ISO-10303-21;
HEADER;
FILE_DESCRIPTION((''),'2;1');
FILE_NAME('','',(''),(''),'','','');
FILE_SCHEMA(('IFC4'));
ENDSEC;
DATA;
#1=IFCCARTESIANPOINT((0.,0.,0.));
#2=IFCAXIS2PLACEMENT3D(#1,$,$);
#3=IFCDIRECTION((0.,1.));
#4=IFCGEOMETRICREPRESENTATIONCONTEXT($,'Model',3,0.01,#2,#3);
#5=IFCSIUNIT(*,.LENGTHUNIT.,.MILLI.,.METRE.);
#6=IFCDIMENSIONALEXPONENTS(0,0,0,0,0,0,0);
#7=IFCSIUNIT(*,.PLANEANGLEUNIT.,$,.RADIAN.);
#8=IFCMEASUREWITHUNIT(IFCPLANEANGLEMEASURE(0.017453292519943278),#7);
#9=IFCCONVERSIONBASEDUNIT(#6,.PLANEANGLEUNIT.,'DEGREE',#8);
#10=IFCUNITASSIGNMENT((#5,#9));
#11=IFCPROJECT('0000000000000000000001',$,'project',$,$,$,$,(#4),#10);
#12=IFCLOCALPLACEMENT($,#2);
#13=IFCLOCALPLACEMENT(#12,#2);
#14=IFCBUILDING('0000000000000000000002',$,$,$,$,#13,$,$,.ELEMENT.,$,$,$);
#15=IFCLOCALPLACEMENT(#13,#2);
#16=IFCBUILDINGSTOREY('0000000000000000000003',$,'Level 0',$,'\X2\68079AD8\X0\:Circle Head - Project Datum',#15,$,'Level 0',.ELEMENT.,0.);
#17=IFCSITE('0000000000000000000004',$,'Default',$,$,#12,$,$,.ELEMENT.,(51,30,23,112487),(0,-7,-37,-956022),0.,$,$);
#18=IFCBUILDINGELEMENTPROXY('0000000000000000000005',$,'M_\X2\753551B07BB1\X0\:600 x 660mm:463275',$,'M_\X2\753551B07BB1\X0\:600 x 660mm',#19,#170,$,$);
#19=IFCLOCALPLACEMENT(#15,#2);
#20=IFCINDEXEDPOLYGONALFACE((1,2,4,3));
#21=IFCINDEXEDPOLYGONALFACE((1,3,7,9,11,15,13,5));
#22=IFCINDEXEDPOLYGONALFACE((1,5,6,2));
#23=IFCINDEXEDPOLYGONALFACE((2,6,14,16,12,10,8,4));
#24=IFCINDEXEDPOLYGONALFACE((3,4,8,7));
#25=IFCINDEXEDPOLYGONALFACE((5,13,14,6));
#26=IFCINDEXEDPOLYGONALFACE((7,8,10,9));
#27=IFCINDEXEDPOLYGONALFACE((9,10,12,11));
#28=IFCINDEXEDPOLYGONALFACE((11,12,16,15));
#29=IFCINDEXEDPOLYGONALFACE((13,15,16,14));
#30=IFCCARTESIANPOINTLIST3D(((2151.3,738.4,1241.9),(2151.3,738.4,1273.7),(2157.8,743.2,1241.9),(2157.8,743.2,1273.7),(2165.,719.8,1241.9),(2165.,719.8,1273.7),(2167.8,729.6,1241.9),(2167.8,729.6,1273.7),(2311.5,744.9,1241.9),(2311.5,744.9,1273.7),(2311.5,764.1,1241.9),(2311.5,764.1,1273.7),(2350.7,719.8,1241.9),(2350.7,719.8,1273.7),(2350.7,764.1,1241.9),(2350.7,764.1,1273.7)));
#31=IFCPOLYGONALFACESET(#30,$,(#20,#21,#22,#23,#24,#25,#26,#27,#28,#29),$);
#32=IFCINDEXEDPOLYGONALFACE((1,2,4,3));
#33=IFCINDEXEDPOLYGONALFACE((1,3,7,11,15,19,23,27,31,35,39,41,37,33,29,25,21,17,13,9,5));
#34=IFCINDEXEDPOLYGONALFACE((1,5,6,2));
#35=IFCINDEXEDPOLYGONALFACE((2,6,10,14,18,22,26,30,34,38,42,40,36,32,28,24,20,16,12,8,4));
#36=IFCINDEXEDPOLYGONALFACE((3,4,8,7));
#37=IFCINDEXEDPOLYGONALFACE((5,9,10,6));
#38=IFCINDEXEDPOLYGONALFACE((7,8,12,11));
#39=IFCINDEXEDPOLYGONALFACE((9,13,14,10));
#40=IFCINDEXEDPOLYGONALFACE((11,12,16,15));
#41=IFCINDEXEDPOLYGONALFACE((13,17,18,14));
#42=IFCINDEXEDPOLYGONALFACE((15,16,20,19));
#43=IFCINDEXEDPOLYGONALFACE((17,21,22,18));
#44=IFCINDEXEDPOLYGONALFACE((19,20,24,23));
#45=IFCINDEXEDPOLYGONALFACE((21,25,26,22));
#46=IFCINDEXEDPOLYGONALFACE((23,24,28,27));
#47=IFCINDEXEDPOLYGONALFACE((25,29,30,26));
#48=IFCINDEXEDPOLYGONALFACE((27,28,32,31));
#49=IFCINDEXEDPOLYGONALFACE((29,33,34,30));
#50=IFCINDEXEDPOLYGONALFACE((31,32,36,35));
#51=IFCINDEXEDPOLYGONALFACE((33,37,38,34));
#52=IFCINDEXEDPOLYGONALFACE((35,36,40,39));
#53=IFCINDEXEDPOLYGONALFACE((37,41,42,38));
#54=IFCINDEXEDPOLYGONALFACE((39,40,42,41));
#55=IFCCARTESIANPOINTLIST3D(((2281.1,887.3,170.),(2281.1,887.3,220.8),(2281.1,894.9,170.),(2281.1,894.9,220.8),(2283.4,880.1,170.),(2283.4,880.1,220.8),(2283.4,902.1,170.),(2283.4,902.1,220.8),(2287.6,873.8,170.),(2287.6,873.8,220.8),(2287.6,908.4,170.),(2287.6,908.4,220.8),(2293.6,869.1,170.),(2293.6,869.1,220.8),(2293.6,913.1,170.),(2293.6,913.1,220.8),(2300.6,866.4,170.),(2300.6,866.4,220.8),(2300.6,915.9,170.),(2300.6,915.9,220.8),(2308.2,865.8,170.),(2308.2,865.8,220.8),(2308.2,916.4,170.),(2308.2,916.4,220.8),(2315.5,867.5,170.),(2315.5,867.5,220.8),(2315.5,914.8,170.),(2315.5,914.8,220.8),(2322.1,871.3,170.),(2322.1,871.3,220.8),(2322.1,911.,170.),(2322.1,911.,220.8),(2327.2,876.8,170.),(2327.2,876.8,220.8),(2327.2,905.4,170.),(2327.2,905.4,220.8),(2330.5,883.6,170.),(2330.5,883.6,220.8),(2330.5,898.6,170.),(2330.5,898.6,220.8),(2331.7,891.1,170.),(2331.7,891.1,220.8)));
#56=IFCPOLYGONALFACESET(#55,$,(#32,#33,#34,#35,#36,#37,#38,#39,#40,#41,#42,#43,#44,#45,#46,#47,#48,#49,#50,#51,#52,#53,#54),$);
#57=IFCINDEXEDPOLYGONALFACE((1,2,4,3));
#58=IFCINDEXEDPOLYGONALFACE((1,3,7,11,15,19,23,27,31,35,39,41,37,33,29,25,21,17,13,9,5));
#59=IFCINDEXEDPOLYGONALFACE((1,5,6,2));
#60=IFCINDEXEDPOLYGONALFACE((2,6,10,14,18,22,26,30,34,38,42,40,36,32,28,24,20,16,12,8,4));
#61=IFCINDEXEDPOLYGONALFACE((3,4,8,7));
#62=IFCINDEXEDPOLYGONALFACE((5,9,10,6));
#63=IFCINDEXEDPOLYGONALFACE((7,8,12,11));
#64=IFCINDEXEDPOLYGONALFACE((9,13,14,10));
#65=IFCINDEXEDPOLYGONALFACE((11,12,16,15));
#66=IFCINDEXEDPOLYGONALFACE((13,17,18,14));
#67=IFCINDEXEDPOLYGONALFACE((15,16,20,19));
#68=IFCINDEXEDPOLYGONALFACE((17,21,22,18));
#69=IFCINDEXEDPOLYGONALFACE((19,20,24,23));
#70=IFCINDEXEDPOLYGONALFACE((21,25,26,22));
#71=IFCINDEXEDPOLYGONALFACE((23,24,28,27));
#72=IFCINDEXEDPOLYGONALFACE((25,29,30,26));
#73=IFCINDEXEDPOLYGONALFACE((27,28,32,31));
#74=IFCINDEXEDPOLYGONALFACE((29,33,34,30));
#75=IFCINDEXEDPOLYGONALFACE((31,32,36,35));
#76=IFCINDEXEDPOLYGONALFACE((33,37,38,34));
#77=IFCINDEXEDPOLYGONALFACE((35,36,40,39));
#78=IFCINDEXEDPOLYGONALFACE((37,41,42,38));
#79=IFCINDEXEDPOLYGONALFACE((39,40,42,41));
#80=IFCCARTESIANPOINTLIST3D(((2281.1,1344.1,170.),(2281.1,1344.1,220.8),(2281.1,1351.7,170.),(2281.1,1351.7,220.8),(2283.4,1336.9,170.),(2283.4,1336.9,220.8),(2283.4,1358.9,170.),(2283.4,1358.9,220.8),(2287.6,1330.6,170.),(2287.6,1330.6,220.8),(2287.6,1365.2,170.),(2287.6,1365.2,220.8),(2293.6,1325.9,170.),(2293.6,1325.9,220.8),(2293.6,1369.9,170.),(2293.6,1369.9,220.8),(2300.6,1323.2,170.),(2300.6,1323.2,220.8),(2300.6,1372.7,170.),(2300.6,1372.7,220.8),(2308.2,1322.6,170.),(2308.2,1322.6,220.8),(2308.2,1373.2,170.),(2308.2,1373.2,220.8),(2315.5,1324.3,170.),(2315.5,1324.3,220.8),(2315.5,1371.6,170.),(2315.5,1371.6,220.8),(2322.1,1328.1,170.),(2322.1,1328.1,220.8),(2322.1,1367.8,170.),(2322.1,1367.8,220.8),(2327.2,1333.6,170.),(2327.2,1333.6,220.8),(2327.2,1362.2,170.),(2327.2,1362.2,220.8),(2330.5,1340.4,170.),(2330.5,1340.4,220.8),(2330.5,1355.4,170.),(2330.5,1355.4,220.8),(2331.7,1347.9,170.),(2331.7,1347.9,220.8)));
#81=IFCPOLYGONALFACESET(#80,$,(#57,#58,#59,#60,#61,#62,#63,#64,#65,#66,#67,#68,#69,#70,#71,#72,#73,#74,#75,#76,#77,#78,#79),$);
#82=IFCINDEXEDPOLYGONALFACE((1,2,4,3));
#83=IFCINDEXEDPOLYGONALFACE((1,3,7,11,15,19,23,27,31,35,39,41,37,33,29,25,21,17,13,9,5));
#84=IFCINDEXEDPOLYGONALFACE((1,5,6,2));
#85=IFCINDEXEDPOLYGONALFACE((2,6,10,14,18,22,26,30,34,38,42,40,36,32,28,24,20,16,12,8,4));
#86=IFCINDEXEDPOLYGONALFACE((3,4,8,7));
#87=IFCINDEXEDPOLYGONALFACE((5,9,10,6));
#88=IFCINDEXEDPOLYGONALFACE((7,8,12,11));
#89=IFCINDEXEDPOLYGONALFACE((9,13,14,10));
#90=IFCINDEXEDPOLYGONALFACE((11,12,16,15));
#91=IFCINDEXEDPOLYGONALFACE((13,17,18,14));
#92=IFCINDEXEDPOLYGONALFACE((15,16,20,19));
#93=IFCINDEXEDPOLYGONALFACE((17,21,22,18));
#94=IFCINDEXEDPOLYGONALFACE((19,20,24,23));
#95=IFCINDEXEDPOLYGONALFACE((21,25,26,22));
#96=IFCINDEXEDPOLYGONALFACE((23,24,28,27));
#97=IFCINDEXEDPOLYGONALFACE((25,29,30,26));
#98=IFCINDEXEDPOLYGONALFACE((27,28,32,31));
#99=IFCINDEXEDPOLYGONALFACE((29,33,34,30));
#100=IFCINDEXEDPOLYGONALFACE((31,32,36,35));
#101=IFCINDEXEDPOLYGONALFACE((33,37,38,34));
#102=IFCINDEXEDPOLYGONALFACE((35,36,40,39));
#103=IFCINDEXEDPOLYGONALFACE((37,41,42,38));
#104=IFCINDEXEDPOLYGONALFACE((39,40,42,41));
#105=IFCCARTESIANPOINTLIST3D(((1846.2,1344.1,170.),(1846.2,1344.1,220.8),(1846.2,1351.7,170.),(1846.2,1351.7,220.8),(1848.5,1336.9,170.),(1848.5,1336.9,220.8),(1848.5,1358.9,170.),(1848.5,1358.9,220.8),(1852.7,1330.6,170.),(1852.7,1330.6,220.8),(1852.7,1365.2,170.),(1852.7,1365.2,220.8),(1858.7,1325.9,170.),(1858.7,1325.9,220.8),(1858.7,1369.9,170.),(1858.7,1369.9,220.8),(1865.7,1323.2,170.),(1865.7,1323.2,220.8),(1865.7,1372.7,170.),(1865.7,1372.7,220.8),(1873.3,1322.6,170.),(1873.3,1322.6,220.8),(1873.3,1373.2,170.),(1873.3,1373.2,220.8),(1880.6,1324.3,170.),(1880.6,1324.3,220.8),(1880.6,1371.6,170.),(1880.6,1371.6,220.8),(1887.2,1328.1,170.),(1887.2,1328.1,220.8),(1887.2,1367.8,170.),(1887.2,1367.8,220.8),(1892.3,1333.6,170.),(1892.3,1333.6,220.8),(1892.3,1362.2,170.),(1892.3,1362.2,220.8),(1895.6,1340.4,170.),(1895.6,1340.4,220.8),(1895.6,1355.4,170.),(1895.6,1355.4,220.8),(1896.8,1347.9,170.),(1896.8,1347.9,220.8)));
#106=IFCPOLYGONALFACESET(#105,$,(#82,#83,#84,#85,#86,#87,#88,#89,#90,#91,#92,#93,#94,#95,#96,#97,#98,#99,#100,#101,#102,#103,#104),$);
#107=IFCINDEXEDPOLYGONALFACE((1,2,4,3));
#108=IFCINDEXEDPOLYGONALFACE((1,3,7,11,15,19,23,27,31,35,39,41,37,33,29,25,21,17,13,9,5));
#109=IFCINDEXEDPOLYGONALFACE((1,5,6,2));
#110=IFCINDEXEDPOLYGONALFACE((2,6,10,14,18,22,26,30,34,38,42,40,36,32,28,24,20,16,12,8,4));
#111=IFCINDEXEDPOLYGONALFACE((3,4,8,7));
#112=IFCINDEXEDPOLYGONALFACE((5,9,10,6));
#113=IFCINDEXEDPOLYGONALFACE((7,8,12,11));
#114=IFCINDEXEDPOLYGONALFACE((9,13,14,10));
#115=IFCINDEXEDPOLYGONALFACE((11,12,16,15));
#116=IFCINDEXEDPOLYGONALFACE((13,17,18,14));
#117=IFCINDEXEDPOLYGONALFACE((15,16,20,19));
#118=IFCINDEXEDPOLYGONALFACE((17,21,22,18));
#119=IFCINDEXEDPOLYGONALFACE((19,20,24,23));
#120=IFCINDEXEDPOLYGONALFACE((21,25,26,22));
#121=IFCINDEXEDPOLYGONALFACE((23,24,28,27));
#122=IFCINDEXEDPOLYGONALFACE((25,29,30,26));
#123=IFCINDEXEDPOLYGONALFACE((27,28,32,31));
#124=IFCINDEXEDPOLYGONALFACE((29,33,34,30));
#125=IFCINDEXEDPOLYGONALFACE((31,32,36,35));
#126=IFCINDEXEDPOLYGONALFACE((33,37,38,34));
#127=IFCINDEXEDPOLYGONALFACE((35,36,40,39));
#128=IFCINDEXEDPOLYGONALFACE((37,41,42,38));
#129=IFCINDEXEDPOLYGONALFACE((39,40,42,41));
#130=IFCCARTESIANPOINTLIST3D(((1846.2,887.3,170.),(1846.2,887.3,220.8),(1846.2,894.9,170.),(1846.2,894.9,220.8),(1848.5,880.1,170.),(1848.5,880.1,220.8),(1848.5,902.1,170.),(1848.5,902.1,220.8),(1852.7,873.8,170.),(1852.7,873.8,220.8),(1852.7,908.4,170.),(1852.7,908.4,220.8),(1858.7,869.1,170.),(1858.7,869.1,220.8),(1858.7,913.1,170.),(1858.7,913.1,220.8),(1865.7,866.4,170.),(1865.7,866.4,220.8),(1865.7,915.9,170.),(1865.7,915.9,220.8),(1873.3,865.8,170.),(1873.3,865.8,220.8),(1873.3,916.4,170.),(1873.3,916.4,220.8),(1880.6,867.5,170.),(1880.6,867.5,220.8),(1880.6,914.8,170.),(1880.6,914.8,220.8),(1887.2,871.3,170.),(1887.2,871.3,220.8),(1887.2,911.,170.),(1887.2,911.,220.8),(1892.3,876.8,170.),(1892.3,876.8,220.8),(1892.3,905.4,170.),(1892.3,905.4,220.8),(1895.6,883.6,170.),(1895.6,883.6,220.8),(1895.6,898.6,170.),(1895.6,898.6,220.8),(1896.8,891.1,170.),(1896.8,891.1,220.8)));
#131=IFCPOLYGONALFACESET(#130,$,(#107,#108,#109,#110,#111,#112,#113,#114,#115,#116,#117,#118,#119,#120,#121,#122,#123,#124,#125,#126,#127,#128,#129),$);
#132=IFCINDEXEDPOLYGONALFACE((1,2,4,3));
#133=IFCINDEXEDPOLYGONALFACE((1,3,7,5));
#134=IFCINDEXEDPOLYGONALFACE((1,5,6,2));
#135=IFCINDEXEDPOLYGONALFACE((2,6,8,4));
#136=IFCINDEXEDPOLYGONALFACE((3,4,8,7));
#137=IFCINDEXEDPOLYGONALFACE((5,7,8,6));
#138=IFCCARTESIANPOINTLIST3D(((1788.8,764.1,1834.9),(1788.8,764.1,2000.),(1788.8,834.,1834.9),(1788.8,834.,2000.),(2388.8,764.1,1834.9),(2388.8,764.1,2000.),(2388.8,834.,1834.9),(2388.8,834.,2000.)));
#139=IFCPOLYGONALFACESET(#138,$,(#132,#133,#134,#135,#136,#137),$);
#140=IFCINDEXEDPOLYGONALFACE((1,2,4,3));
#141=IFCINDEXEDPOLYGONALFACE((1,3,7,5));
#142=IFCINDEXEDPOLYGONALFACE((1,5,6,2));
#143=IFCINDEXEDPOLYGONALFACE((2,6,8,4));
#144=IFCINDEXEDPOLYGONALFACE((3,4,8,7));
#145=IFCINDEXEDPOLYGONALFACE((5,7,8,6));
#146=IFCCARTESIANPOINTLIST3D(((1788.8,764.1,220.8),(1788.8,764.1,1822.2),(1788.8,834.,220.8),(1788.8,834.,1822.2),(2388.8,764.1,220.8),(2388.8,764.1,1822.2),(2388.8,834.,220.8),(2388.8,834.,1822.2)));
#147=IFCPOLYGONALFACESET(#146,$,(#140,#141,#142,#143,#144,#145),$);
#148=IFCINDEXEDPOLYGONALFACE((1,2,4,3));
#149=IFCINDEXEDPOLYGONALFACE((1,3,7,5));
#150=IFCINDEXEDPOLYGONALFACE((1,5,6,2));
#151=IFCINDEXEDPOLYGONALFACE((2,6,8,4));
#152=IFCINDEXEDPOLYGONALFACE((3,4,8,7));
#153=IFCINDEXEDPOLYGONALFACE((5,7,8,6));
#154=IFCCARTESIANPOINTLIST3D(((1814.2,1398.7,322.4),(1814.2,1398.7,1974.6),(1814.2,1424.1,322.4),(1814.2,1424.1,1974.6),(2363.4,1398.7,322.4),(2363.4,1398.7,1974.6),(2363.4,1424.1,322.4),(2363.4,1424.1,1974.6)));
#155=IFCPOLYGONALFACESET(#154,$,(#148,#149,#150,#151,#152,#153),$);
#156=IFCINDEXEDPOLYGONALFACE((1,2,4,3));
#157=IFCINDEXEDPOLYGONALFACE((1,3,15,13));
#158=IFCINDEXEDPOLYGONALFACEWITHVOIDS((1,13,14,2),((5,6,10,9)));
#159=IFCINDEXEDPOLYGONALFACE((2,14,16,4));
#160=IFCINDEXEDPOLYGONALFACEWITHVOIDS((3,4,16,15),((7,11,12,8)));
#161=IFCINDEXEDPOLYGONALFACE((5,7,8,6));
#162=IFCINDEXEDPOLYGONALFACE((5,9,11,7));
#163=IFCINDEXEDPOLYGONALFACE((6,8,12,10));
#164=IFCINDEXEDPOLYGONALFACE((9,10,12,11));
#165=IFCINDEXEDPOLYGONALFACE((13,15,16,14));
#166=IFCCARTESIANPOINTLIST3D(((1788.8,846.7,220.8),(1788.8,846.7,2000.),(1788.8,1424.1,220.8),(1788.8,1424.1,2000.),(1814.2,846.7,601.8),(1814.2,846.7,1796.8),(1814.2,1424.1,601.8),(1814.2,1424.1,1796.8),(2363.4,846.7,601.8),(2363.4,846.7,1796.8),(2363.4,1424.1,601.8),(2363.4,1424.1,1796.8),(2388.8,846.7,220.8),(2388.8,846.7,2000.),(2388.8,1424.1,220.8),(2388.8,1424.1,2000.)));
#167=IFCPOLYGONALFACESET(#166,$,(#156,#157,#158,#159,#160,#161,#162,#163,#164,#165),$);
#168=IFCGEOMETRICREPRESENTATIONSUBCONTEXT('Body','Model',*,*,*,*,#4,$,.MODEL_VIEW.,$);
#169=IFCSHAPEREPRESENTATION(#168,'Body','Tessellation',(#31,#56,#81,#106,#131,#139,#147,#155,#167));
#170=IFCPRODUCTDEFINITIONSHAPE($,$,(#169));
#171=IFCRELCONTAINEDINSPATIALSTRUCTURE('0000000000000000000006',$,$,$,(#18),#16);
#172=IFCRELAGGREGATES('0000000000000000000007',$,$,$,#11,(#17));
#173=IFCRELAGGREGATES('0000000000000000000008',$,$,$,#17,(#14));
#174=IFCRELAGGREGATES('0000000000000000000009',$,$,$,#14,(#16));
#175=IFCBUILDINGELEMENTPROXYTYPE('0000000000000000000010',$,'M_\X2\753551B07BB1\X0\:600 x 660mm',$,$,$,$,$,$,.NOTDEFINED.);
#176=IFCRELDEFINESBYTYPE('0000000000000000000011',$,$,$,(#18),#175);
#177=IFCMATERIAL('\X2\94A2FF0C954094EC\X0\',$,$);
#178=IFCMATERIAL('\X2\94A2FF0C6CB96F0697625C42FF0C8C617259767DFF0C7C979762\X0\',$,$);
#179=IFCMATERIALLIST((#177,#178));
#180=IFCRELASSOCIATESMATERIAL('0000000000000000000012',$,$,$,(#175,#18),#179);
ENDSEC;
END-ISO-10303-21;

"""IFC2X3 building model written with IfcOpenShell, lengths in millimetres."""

from ifc_helpers import new_model, entity, si_unit, converted_unit, direction, frame, frame_2d, origin, origin_2d_with_axis, place, context, subcontext, project, spatial, polyline, rectangle, circle, outline, extrude, source, transform, mapped, material, material_list, type_object, type_shapes, element, save


model = new_model("IFC2X3")

# Units and contexts
model_context = context("Model", 3, precision=0.01, world=origin(), true_north=direction((0.0, 1.0)))
body_context = subcontext(model_context, "Body", "Model", "MODEL_VIEW")
ifc_project = project(units=[si_unit("LENGTHUNIT", "METRE", prefix="MILLI"), converted_unit("PLANEANGLEUNIT", "DEGREE", entity("IfcPlaneAngleMeasure", 0.017453292519943278), si_unit("PLANEANGLEUNIT", "RADIAN"), dimensions=[0, 0, 0, 0, 0, 0, 0])], contexts=[model_context])

# Site, building, storey
site_placement = place(None, origin())
site = spatial("IfcSite", under=ifc_project, at=site_placement, Name="Default", CompositionType="ELEMENT", RefLatitude=(51, 30, 23, 112487), RefLongitude=(0, -7, -37, -956022), RefElevation=0.0)
building_placement = place(site_placement, origin())
building = spatial("IfcBuilding", under=site, at=building_placement, CompositionType="ELEMENT")
storey_placement = place(building_placement, origin())
storey = spatial("IfcBuildingStorey", under=building, at=storey_placement, Name="Level 0", ObjectType="标高:Circle Head - Project Datum", LongName="Level 0", CompositionType="ELEMENT", Elevation=0.0)

# Building element proxy
ifc_material_1 = material(Name="钢，镀铬")
ifc_material_2 = material(Name="钢，油漆面层，象牙白，粗面")
ifc_material_list_1 = material_list([ifc_material_1, ifc_material_2])
building_element_proxy_type_1 = type_object("IfcBuildingElementProxyType", Name="M_电冰箱:600 x 660mm", PredefinedType="NOTDEFINED", material=ifc_material_list_1)
shared_shape_1 = source(origin(), body_context, "Body", "SweptSolid", [
    extrude(outline(polyline([(-20.7, -104.9), (23.6, -104.9), (23.6, -65.7), (4.4, -65.7), (-10.8, 78.0), (2.7, 88.0), (-2.1, 94.5), (-20.7, 80.8), (-20.7, -104.9)])), frame((103.2, -387.4, 1071.9), z_axis=(0.0, 0.0, 1.0), x_axis=(0.0, 1.0, 0.0)), (0.0, 0.0, 1.0), 31.7),
    extrude(circle(Radius=25.4, at=origin_2d_with_axis()), frame((163.6, -236.8, 0.0)), (0.0, 0.0, 1.0), 50.8),
    extrude(circle(Radius=25.4, at=origin_2d_with_axis()), frame((163.6, 220.0, 0.0)), (0.0, 0.0, 1.0), 50.8),
    extrude(circle(Radius=25.4, at=origin_2d_with_axis()), frame((-271.3, 220.0, 0.0)), (0.0, 0.0, 1.0), 50.8),
    extrude(circle(Radius=25.4, at=frame_2d((0.0, 0.0), x_axis=(1.0, 0.0))), frame((-271.3, -236.8, 0.0)), (0.0, 0.0, 1.0), 50.8),
    extrude(rectangle(XDim=69.8, YDim=600.0, at=frame_2d((0.0, 0.0), x_axis=(1.0, 0.0))), frame((-53.8, -328.9, 1664.9), z_axis=(0.0, 0.0, 1.0), x_axis=(0.0, 1.0, 0.0)), (0.0, 0.0, 1.0), 165.1),
    extrude(rectangle(XDim=69.8, YDim=600.0, at=frame_2d((0.0, 0.0), x_axis=(1.0, 0.0))), frame((-53.8, -328.9, 50.8), z_axis=(0.0, 0.0, 1.0), x_axis=(0.0, 1.0, 0.0)), (0.0, 0.0, 1.0), 1601.4),
    extrude(rectangle(XDim=25.4, YDim=549.2, at=origin_2d_with_axis()), frame((-53.8, 283.5, 152.4), z_axis=(0.0, 0.0, 1.0), x_axis=(0.0, 1.0, 0.0)), (0.0, 0.0, 1.0), 1652.2),
    extrude(outline(polyline([(-889.6, -300.0), (889.6, -300.0), (889.6, 300.0), (-889.6, 300.0), (-889.6, -300.0)]), holes=[polyline([(-686.4, -274.6), (-686.4, 274.6), (508.6, 274.6), (508.6, -274.6), (-686.4, -274.6)])]), frame((-53.8, -281.2, 940.4), z_axis=(0.0, 1.0, 0.0), x_axis=(0.0, 0.0, -1.0)), (0.0, 0.0, 1.0), 577.4),
])
type_shapes(building_element_proxy_type_1, [shared_shape_1])
proxy_1_placement = place(storey_placement, frame((2142.6, 1127.9, 170.0)))
element("IfcBuildingElementProxy", 1, at=proxy_1_placement, inside=storey, type_object=building_element_proxy_type_1, material=ifc_material_list_1, Name="M_电冰箱:600 x 660mm:463275", ObjectType="M_电冰箱:600 x 660mm", context=body_context, shape_type="MappedRepresentation", body=[
    mapped(shared_shape_1, transform((0.0, 0.0, 0.0), scale=1.0)),
])

save(model, "model.ifc")
